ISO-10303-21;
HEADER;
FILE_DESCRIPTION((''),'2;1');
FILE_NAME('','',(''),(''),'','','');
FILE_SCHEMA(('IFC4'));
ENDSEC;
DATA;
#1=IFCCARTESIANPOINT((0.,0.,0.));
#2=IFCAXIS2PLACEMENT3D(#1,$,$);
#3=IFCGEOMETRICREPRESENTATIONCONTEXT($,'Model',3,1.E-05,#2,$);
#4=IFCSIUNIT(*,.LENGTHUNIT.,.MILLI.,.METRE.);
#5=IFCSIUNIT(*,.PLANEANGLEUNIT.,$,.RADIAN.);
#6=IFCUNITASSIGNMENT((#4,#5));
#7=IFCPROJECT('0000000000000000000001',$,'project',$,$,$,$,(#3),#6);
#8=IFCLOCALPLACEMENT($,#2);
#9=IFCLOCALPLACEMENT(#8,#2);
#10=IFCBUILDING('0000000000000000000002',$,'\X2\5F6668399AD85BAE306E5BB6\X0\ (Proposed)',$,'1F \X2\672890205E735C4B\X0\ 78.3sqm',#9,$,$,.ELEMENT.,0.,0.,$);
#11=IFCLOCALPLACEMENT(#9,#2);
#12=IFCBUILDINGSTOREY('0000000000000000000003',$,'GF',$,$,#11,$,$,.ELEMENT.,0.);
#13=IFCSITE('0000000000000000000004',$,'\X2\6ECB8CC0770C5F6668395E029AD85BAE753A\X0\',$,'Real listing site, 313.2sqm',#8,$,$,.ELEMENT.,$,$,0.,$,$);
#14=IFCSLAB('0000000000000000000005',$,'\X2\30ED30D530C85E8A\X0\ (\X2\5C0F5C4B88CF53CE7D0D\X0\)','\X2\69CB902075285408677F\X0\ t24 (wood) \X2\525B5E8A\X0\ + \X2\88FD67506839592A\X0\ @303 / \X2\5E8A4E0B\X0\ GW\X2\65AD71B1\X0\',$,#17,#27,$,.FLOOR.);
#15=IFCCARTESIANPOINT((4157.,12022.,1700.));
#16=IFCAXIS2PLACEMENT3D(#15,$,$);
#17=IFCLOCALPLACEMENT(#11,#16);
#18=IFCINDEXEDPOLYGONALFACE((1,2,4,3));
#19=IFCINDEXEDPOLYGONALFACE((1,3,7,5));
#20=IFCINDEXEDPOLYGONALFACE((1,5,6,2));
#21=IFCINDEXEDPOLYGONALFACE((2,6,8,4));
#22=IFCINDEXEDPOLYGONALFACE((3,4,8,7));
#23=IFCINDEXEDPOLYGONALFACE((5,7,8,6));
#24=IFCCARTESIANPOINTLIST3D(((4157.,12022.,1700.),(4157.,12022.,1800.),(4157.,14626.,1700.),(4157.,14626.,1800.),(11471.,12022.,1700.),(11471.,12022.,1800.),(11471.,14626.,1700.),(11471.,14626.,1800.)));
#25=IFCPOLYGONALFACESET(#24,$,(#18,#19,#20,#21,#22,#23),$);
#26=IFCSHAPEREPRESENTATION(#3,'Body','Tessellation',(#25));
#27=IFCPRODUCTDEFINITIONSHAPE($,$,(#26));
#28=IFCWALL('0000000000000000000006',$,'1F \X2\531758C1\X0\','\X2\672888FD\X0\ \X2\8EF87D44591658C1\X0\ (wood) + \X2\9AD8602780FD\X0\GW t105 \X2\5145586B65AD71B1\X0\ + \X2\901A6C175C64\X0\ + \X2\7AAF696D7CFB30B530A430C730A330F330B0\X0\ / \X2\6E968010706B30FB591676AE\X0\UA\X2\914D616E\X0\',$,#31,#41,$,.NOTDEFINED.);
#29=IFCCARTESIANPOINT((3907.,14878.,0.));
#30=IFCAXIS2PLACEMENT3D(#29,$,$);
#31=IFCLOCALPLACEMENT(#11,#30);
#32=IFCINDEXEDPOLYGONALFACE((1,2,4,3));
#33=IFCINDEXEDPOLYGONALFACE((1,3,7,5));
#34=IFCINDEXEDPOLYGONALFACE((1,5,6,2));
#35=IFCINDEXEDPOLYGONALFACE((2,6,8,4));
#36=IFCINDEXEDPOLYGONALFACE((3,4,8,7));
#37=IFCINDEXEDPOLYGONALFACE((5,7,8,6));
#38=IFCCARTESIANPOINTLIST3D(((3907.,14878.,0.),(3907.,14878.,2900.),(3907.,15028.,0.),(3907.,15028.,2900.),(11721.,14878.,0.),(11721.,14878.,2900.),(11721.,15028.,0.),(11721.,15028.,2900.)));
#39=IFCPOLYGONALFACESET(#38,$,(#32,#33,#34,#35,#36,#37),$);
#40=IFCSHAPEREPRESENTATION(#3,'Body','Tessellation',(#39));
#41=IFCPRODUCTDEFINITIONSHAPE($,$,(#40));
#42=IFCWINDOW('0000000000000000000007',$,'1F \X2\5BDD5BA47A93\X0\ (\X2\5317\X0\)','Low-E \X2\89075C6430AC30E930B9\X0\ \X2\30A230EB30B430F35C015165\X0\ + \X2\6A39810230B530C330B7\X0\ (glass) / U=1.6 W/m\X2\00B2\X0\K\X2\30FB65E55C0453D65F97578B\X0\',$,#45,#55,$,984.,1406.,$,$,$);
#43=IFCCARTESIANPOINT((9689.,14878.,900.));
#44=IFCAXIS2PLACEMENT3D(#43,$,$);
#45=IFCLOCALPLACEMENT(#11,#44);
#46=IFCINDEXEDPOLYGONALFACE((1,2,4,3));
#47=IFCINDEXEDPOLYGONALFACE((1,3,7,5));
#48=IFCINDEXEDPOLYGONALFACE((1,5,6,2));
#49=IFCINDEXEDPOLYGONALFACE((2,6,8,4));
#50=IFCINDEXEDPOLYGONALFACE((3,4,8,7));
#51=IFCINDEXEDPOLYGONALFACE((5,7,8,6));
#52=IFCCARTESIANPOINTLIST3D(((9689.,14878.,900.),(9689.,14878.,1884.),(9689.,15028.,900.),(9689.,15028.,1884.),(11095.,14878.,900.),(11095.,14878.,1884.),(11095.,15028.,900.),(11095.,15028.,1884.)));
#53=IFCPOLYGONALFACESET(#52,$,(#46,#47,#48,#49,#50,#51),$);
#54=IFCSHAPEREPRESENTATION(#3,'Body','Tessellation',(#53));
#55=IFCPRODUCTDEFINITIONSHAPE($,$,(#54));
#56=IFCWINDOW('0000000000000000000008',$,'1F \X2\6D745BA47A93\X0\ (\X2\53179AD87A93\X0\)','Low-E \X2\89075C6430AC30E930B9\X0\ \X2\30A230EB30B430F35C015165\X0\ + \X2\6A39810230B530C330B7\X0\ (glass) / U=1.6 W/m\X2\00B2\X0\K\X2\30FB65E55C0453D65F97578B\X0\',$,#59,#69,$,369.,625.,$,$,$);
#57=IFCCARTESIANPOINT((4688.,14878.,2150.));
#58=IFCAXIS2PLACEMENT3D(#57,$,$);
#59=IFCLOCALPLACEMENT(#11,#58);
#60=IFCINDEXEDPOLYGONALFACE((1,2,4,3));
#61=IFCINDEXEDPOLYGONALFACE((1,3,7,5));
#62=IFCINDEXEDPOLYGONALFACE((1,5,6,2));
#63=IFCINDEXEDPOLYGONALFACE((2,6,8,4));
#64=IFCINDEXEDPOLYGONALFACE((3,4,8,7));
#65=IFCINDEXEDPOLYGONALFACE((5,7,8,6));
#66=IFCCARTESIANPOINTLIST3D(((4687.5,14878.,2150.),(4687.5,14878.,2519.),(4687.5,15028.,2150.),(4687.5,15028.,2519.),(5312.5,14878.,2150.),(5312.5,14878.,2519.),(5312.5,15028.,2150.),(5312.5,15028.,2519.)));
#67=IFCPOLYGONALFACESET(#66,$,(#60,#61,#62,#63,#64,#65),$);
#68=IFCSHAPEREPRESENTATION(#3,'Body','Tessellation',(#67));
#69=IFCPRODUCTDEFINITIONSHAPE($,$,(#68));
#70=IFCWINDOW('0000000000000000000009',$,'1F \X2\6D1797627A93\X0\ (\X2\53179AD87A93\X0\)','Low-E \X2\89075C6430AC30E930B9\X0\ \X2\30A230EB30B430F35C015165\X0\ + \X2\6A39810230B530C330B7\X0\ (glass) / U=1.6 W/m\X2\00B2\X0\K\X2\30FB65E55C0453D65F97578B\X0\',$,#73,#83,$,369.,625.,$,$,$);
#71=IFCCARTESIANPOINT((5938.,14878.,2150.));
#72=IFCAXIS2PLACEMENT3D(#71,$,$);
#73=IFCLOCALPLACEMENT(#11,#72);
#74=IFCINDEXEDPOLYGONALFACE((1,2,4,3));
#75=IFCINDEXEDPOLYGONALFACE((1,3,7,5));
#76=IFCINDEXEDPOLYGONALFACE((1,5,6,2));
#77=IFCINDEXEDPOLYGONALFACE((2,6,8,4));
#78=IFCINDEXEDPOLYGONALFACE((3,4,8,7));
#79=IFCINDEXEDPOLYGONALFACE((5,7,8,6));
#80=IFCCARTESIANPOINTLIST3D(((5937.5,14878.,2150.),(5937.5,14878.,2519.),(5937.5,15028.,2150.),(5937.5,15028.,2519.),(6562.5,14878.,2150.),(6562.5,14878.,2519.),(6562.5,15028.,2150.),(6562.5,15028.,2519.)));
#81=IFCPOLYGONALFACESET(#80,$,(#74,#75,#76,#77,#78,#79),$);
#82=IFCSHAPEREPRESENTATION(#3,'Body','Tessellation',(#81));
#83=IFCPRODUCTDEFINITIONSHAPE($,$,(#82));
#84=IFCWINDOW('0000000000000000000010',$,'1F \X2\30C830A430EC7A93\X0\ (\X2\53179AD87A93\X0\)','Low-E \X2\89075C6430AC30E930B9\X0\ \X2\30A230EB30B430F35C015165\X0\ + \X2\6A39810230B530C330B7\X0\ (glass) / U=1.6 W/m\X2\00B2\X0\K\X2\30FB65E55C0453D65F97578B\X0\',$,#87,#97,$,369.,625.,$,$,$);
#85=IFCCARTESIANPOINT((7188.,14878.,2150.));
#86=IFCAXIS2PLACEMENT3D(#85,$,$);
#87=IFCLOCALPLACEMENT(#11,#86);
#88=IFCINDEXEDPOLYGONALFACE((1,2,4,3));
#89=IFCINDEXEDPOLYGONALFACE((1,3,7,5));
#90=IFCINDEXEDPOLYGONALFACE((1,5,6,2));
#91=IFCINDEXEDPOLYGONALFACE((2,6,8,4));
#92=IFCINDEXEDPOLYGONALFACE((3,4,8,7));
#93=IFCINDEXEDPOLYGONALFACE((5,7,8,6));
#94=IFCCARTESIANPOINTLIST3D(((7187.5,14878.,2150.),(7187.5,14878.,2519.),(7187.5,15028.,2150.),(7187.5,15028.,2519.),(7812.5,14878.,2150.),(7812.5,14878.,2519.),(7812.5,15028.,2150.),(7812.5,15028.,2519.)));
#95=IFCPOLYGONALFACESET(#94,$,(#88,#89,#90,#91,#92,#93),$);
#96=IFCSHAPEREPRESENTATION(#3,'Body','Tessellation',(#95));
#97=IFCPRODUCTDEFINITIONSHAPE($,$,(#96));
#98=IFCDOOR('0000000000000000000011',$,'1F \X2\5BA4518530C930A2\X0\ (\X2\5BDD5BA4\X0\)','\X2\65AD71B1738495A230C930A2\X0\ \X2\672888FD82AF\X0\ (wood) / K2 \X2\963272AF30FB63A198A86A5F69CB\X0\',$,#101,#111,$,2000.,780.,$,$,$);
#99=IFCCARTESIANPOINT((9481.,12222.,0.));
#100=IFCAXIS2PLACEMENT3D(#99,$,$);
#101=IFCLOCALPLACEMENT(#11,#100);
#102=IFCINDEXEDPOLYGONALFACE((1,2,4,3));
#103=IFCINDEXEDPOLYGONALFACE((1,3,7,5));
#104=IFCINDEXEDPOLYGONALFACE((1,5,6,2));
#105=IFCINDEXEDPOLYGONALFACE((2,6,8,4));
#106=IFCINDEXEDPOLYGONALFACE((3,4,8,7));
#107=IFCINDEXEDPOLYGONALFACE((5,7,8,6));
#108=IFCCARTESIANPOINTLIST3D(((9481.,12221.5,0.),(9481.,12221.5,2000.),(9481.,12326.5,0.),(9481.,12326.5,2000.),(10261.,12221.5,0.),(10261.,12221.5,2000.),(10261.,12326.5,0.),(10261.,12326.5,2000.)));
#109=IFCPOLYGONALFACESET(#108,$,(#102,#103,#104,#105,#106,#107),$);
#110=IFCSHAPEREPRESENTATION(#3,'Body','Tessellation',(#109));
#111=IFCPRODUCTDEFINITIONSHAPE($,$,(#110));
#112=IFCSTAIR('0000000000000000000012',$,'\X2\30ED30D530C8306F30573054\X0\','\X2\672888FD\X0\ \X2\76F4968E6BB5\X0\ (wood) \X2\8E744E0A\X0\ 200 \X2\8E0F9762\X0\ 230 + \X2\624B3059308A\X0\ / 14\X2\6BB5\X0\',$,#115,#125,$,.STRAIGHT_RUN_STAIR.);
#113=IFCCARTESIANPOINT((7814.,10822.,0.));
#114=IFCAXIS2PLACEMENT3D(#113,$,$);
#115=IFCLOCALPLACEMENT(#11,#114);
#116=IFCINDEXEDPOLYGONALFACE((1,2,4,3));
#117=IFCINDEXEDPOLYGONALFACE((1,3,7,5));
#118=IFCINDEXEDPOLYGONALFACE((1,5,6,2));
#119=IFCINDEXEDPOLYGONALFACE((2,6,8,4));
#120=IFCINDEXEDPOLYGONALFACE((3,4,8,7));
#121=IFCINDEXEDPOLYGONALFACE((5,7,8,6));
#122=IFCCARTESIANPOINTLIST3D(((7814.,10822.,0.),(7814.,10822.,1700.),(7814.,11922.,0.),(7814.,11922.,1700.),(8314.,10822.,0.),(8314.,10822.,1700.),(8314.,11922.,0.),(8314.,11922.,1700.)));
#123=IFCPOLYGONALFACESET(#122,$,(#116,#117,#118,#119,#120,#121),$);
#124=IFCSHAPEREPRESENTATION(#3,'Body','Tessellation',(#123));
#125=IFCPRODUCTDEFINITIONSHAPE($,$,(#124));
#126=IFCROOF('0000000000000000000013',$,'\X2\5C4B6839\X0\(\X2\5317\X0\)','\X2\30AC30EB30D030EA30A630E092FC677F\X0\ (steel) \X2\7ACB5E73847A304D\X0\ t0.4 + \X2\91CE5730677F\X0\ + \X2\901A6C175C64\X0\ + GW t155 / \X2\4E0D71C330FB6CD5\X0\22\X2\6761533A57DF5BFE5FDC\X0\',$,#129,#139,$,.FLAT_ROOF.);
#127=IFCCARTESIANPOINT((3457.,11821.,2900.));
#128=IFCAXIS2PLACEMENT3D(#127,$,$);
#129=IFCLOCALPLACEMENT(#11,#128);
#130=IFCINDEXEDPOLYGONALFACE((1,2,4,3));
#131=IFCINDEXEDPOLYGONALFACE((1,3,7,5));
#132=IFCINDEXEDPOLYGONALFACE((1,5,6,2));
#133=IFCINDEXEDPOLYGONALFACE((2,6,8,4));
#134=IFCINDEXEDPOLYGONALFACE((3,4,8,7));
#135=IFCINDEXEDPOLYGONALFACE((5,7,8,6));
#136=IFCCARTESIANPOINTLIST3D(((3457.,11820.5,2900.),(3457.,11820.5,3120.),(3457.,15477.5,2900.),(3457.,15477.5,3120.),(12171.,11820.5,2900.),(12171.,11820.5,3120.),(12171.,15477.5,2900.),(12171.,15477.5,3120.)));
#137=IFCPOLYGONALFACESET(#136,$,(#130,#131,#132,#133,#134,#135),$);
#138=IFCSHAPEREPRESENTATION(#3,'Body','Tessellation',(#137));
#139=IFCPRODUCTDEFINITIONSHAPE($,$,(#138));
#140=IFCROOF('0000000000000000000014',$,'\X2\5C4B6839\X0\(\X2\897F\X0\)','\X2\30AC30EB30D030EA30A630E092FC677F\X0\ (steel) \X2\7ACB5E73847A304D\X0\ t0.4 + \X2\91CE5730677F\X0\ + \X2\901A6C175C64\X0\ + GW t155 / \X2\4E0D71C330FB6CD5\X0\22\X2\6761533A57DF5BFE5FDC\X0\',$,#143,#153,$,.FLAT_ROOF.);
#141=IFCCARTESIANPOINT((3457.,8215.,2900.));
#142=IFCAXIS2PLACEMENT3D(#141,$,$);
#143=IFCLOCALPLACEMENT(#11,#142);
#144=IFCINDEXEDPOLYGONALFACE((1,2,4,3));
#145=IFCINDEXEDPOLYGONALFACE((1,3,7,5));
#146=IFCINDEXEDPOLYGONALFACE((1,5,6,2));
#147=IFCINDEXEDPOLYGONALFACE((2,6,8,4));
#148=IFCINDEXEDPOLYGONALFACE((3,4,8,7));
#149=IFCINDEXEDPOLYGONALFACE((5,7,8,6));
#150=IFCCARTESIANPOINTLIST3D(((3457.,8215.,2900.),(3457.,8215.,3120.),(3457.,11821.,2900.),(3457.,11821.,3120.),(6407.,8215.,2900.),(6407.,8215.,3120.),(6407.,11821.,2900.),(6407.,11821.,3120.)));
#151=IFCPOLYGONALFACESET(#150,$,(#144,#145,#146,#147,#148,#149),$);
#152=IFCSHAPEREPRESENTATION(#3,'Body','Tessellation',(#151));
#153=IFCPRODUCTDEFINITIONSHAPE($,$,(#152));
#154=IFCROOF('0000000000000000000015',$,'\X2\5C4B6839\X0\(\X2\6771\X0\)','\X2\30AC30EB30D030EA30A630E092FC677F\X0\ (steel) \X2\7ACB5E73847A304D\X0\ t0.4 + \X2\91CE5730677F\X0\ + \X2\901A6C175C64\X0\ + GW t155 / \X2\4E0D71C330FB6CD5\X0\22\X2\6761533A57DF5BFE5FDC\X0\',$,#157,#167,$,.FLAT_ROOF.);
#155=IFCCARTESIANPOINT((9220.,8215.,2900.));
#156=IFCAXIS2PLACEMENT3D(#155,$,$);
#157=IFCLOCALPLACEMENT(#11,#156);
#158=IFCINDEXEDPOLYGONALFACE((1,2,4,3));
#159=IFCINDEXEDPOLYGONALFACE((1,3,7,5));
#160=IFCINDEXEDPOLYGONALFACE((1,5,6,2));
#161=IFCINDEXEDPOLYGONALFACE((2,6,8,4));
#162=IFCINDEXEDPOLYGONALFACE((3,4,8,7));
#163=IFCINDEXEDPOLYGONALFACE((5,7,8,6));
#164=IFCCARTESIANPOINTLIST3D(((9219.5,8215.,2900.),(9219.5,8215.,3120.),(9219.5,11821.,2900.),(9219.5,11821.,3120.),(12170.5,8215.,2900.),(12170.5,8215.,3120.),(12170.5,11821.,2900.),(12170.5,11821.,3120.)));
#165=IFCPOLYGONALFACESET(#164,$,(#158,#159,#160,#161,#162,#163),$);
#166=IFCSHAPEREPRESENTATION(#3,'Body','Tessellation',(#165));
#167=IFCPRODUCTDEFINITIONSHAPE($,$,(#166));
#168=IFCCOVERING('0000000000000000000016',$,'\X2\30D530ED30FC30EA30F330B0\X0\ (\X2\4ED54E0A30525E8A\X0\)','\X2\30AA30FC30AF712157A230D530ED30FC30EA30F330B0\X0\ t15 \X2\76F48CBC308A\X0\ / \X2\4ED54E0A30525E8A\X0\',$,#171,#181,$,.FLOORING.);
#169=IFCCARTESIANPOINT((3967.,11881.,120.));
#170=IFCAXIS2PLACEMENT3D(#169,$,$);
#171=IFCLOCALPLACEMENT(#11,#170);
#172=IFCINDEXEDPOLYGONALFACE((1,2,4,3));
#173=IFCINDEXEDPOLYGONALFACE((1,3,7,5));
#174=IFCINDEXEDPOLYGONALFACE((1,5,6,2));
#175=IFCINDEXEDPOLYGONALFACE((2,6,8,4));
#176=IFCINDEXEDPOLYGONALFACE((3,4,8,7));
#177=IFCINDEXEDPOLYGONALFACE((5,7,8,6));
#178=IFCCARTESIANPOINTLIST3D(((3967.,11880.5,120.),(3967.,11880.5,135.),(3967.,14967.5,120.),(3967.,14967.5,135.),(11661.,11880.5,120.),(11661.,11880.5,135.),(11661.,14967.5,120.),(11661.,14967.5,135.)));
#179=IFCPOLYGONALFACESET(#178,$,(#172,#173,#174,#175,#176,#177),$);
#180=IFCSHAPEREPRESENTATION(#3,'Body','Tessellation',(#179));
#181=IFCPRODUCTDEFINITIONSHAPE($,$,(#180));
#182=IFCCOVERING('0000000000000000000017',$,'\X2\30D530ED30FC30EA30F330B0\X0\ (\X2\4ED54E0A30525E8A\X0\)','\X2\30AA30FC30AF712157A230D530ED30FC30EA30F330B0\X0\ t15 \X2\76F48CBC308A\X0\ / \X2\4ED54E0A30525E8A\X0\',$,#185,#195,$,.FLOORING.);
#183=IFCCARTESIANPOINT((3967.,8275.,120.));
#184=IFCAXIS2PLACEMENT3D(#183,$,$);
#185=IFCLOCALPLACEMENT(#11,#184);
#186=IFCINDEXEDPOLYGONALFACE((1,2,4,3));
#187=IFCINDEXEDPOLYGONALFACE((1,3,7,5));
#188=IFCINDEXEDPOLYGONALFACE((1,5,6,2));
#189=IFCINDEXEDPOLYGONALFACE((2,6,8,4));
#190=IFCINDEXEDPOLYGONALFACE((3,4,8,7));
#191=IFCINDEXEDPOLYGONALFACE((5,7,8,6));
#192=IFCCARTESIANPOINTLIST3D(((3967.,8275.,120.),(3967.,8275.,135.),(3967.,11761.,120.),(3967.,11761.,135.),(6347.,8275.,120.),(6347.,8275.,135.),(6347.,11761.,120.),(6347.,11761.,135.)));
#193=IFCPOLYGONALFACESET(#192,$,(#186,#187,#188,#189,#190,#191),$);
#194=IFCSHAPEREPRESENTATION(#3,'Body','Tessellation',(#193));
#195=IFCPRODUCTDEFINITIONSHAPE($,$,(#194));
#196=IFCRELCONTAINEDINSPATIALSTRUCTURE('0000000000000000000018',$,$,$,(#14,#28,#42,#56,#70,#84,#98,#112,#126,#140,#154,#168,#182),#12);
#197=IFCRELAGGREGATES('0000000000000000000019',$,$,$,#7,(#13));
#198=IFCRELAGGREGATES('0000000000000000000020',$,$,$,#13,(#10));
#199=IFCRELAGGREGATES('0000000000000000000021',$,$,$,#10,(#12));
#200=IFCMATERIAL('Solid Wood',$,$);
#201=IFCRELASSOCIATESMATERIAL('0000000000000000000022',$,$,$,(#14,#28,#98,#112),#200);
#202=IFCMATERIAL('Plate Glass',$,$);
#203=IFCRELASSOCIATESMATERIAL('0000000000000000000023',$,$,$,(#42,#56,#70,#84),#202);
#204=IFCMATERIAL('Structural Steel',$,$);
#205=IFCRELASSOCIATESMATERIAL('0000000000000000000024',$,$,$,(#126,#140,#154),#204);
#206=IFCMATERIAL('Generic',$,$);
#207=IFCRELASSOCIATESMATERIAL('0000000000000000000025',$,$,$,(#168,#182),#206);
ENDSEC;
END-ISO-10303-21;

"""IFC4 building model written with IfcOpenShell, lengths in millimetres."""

from ifc_helpers import new_model, si_unit, frame, frame_2d, origin, place, context, project, spatial, rectangle, extrude, material, element, fill, save


model = new_model("IFC4")

# Units and contexts
model_context = context("Model", 3, precision=1e-05, world=origin())
ifc_project = project(units=[si_unit("LENGTHUNIT", "METRE", prefix="MILLI"), si_unit("PLANEANGLEUNIT", "RADIAN")], contexts=[model_context])

# Site, building, storey
site_placement = place(None, origin())
site = spatial("IfcSite", under=ifc_project, at=site_placement, Name="滋賀県彦根市高宮町", ObjectType="Real listing site, 313.2sqm", CompositionType="ELEMENT", RefElevation=0.0)
building_placement = place(site_placement, origin())
building = spatial("IfcBuilding", under=site, at=building_placement, Name="彦根高宮の家 (Proposed)", ObjectType="1F 木造平屋 78.3sqm", CompositionType="ELEMENT", ElevationOfRefHeight=0.0, ElevationOfTerrain=0.0)
storey_placement = place(building_placement, origin())
storey = spatial("IfcBuildingStorey", under=building, at=storey_placement, Name="GF", CompositionType="ELEMENT", Elevation=0.0)

# Slab
ifc_material_1 = material(Name="Solid Wood")
slab_1_placement = place(storey_placement, frame((4157.0, 12022.0, 1700.0)))
element("IfcSlab", 1, at=slab_1_placement, inside=storey, material=ifc_material_1, Name="ロフト床 (小屋裏収納)", Description="構造用合板 t24 (wood) 剛床 + 製材根太 @303 / 床下 GW断熱", PredefinedType="FLOOR", context=model_context, shape_type="SweptSolid", body=[
    extrude(rectangle(XDim=7314.0, YDim=2604.0, at=frame_2d((3657.0, 1302.0))), frame((4157.0, 12022.0, 1700.0)), (0.0, 0.0, 1.0), 100.0),
])

# Wall, openings, windows
wall_1_placement = place(storey_placement, frame((3907.0, 14878.0, 0.0)))
wall_1 = element("IfcWall", 2, at=wall_1_placement, inside=storey, material=ifc_material_1, Name="1F 北壁", Description="木製 軸組外壁 (wood) + 高性能GW t105 充填断熱 + 通気層 + 窯業系サイディング / 準耐火・外皮UA配慮", PredefinedType="NOTDEFINED", context=model_context, shape_type="SweptSolid", body=[
    extrude(rectangle(XDim=7814.0, YDim=150.0, at=frame_2d((3907.0, 75.0))), frame((3907.0, 14878.0, 0.0)), (0.0, 0.0, 1.0), 2900.0),
])
opening_1_placement = place(storey_placement, frame((9689.0, 14878.0, 900.0)))
opening_1 = element("IfcOpeningElement", 3, at=opening_1_placement, cuts=wall_1, PredefinedType="NOTDEFINED", context=model_context, shape_type="SweptSolid", body=[
    extrude(rectangle(XDim=1406.0, YDim=150.0, at=frame_2d((703.0, 75.0))), frame((9689.0, 14878.0, 900.0)), (0.0, 0.0, 1.0), 984.0),
])
opening_2_placement = place(storey_placement, frame((4688.0, 14878.0, 2150.0)))
opening_2 = element("IfcOpeningElement", 4, at=opening_2_placement, cuts=wall_1, PredefinedType="NOTDEFINED", context=model_context, shape_type="SweptSolid", body=[
    extrude(rectangle(XDim=625.0, YDim=150.0, at=frame_2d((312.0, 75.0))), frame((4688.0, 14878.0, 2150.0)), (0.0, 0.0, 1.0), 369.0),
])
opening_3_placement = place(storey_placement, frame((5938.0, 14878.0, 2150.0)))
opening_3 = element("IfcOpeningElement", 5, at=opening_3_placement, cuts=wall_1, PredefinedType="NOTDEFINED", context=model_context, shape_type="SweptSolid", body=[
    extrude(rectangle(XDim=625.0, YDim=150.0, at=frame_2d((312.0, 75.0))), frame((5938.0, 14878.0, 2150.0)), (0.0, 0.0, 1.0), 369.0),
])
opening_4_placement = place(storey_placement, frame((7188.0, 14878.0, 2150.0)))
opening_4 = element("IfcOpeningElement", 6, at=opening_4_placement, cuts=wall_1, PredefinedType="NOTDEFINED", context=model_context, shape_type="SweptSolid", body=[
    extrude(rectangle(XDim=625.0, YDim=150.0, at=frame_2d((312.0, 75.0))), frame((7188.0, 14878.0, 2150.0)), (0.0, 0.0, 1.0), 369.0),
])
ifc_material_2 = material(Name="Plate Glass")
window_1_placement = place(storey_placement, frame((9689.0, 14878.0, 900.0)))
window_1 = element("IfcWindow", 7, at=window_1_placement, inside=storey, material=ifc_material_2, Name="1F 寝室窓 (北)", Description="Low-E 複層ガラス アルゴン封入 + 樹脂サッシ (glass) / U=1.6 W/m²K・日射取得型", OverallHeight=984.0, OverallWidth=1406.0, context=model_context, shape_type="SweptSolid", body=[
    extrude(rectangle(XDim=1406.0, YDim=150.0, at=frame_2d((703.0, 75.0))), frame((9689.0, 14878.0, 900.0)), (0.0, 0.0, 1.0), 984.0),
])
fill(opening_1, window_1)
window_2_placement = place(storey_placement, frame((4688.0, 14878.0, 2150.0)))
window_2 = element("IfcWindow", 8, at=window_2_placement, inside=storey, material=ifc_material_2, Name="1F 浴室窓 (北高窓)", Description="Low-E 複層ガラス アルゴン封入 + 樹脂サッシ (glass) / U=1.6 W/m²K・日射取得型", OverallHeight=369.0, OverallWidth=625.0, context=model_context, shape_type="SweptSolid", body=[
    extrude(rectangle(XDim=625.0, YDim=150.0, at=frame_2d((312.0, 75.0))), frame((4688.0, 14878.0, 2150.0)), (0.0, 0.0, 1.0), 369.0),
])
fill(opening_2, window_2)
window_3_placement = place(storey_placement, frame((5938.0, 14878.0, 2150.0)))
window_3 = element("IfcWindow", 9, at=window_3_placement, inside=storey, material=ifc_material_2, Name="1F 洗面窓 (北高窓)", Description="Low-E 複層ガラス アルゴン封入 + 樹脂サッシ (glass) / U=1.6 W/m²K・日射取得型", OverallHeight=369.0, OverallWidth=625.0, context=model_context, shape_type="SweptSolid", body=[
    extrude(rectangle(XDim=625.0, YDim=150.0, at=frame_2d((312.0, 75.0))), frame((5938.0, 14878.0, 2150.0)), (0.0, 0.0, 1.0), 369.0),
])
fill(opening_3, window_3)
window_4_placement = place(storey_placement, frame((7188.0, 14878.0, 2150.0)))
window_4 = element("IfcWindow", 10, at=window_4_placement, inside=storey, material=ifc_material_2, Name="1F トイレ窓 (北高窓)", Description="Low-E 複層ガラス アルゴン封入 + 樹脂サッシ (glass) / U=1.6 W/m²K・日射取得型", OverallHeight=369.0, OverallWidth=625.0, context=model_context, shape_type="SweptSolid", body=[
    extrude(rectangle(XDim=625.0, YDim=150.0, at=frame_2d((312.0, 75.0))), frame((7188.0, 14878.0, 2150.0)), (0.0, 0.0, 1.0), 369.0),
])
fill(opening_4, window_4)

# Door
door_1_placement = place(storey_placement, frame((9481.0, 12222.0, 0.0)))
element("IfcDoor", 11, at=door_1_placement, inside=storey, material=ifc_material_1, Name="1F 室内ドア (寝室)", Description="断熱玄関ドア 木製芯 (wood) / K2 防犯・採風機構", OverallHeight=2000.0, OverallWidth=780.0, context=model_context, shape_type="SweptSolid", body=[
    extrude(rectangle(XDim=780.0, YDim=105.0, at=frame_2d((390.0, 52.0))), frame((9481.0, 12222.0, 0.0)), (0.0, 0.0, 1.0), 2000.0),
])

# Stair
stair_placement = place(storey_placement, frame((7814.0, 10822.0, 0.0)))
element("IfcStair", 12, at=stair_placement, inside=storey, material=ifc_material_1, Name="ロフトはしご", Description="木製 直階段 (wood) 蹴上 200 踏面 230 + 手すり / 14段", PredefinedType="STRAIGHT_RUN_STAIR", context=model_context, shape_type="SweptSolid", body=[
    extrude(rectangle(XDim=500.0, YDim=1100.0, at=frame_2d((250.0, 550.0))), frame((7814.0, 10822.0, 0.0)), (0.0, 0.0, 1.0), 1700.0),
])

# Roofs
ifc_material_3 = material(Name="Structural Steel")
roof_1_placement = place(storey_placement, frame((3457.0, 11821.0, 2900.0)))
element("IfcRoof", 13, at=roof_1_placement, inside=storey, material=ifc_material_3, Name="屋根(北)", Description="ガルバリウム鋼板 (steel) 立平葺き t0.4 + 野地板 + 通気層 + GW t155 / 不燃・法22条区域対応", PredefinedType="FLAT_ROOF", context=model_context, shape_type="SweptSolid", body=[
    extrude(rectangle(XDim=8714.0, YDim=3657.0, at=frame_2d((4357.0, 1828.0))), frame((3457.0, 11821.0, 2900.0)), (0.0, 0.0, 1.0), 220.0),
])
roof_2_placement = place(storey_placement, frame((3457.0, 8215.0, 2900.0)))
element("IfcRoof", 14, at=roof_2_placement, inside=storey, material=ifc_material_3, Name="屋根(西)", Description="ガルバリウム鋼板 (steel) 立平葺き t0.4 + 野地板 + 通気層 + GW t155 / 不燃・法22条区域対応", PredefinedType="FLAT_ROOF", context=model_context, shape_type="SweptSolid", body=[
    extrude(rectangle(XDim=2950.0, YDim=3606.0, at=frame_2d((1475.0, 1803.0))), frame((3457.0, 8215.0, 2900.0)), (0.0, 0.0, 1.0), 220.0),
])
roof_3_placement = place(storey_placement, frame((9220.0, 8215.0, 2900.0)))
element("IfcRoof", 15, at=roof_3_placement, inside=storey, material=ifc_material_3, Name="屋根(東)", Description="ガルバリウム鋼板 (steel) 立平葺き t0.4 + 野地板 + 通気層 + GW t155 / 不燃・法22条区域対応", PredefinedType="FLAT_ROOF", context=model_context, shape_type="SweptSolid", body=[
    extrude(rectangle(XDim=2951.0, YDim=3606.0, at=frame_2d((1475.0, 1803.0))), frame((9220.0, 8215.0, 2900.0)), (0.0, 0.0, 1.0), 220.0),
])

# Coverings
ifc_material_4 = material(Name="Generic")
covering_1_placement = place(storey_placement, frame((3967.0, 11881.0, 120.0)))
element("IfcCovering", 16, at=covering_1_placement, inside=storey, material=ifc_material_4, Name="フローリング (仕上げ床)", Description="オーク無垢フローリング t15 直貼り / 仕上げ床", PredefinedType="FLOORING", context=model_context, shape_type="SweptSolid", body=[
    extrude(rectangle(XDim=7694.0, YDim=3087.0, at=frame_2d((3847.0, 1543.0))), frame((3967.0, 11881.0, 120.0)), (0.0, 0.0, 1.0), 15.0),
])
covering_2_placement = place(storey_placement, frame((3967.0, 8275.0, 120.0)))
element("IfcCovering", 17, at=covering_2_placement, inside=storey, material=ifc_material_4, Name="フローリング (仕上げ床)", Description="オーク無垢フローリング t15 直貼り / 仕上げ床", PredefinedType="FLOORING", context=model_context, shape_type="SweptSolid", body=[
    extrude(rectangle(XDim=2380.0, YDim=3486.0, at=frame_2d((1190.0, 1743.0))), frame((3967.0, 8275.0, 120.0)), (0.0, 0.0, 1.0), 15.0),
])

save(model, "model.ifc")
